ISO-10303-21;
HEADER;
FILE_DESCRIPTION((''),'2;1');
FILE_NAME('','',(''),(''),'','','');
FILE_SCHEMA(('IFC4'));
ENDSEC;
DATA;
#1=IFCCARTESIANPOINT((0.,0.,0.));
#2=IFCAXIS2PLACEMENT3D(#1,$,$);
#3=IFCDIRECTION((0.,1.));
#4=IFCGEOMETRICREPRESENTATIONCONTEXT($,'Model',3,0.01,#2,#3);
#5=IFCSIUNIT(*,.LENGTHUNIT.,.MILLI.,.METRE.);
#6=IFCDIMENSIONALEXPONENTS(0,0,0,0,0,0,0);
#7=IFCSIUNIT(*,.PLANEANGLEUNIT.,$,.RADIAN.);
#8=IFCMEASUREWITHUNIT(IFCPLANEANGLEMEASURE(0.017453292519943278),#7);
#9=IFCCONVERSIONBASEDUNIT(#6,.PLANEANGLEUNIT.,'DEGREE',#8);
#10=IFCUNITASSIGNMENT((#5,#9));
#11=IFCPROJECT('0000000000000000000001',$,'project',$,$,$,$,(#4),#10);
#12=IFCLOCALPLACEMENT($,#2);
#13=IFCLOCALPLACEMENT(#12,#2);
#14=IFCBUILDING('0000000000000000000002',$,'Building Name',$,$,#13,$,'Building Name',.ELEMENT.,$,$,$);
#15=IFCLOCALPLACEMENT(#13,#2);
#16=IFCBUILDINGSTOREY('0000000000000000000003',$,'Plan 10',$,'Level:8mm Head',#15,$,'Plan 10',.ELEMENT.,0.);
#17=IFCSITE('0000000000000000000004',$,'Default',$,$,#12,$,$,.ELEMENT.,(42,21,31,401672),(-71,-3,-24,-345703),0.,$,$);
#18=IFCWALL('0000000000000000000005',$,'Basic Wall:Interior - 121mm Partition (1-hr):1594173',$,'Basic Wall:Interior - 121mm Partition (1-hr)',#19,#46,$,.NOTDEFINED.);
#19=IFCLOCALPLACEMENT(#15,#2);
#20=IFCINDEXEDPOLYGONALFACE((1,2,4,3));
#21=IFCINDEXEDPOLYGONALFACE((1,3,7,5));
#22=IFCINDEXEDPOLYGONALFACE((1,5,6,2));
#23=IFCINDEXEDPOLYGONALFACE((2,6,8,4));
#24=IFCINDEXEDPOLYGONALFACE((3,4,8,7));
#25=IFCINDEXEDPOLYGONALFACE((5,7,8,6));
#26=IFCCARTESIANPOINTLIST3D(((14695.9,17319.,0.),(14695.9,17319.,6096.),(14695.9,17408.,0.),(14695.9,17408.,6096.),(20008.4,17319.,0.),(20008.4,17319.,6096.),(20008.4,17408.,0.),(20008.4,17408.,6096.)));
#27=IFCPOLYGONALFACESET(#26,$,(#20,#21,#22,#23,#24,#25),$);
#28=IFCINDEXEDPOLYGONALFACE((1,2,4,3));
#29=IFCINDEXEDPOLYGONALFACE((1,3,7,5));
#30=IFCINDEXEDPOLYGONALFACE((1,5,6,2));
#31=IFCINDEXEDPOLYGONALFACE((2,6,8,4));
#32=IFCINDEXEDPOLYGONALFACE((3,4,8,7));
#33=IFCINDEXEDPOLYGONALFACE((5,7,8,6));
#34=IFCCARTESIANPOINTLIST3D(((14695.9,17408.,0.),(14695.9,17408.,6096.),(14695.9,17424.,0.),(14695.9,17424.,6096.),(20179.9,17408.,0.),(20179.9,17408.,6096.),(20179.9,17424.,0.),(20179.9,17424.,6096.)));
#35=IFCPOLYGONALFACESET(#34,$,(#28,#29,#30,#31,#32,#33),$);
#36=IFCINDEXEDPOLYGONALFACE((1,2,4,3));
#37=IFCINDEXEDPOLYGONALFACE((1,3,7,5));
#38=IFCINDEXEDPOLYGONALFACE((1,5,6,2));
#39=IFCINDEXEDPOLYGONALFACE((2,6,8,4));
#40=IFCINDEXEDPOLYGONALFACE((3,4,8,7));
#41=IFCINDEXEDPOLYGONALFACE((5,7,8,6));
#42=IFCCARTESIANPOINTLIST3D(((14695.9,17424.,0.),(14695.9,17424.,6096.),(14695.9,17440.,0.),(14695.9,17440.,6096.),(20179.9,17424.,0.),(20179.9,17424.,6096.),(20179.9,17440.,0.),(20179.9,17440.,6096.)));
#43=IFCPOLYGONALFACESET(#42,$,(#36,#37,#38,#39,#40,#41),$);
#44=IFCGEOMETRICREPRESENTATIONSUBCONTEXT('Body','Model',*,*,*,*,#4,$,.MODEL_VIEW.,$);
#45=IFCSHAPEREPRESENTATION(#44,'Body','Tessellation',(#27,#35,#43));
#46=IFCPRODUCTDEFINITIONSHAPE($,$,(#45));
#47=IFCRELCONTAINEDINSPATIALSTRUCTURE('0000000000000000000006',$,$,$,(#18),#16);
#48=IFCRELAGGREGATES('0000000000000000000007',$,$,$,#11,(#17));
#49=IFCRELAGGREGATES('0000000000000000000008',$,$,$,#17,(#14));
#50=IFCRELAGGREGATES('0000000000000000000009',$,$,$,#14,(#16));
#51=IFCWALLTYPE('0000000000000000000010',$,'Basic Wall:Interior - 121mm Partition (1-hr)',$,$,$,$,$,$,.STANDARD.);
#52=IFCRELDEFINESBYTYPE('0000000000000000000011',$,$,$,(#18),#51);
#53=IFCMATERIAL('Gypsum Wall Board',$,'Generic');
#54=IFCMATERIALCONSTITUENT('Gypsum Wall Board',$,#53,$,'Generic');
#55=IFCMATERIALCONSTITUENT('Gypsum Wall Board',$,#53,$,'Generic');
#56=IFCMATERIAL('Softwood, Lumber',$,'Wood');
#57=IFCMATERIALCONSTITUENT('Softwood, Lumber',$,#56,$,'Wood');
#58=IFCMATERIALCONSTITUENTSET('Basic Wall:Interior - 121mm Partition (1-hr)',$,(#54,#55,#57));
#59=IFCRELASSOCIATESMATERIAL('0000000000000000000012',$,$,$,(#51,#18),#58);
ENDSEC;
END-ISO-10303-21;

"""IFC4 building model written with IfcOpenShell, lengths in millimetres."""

from ifc_helpers import new_model, entity, si_unit, converted_unit, direction, frame, origin, place, context, subcontext, project, spatial, indexed_curve, outline, extrude, material, constituent, constituent_set, type_object, element, save


model = new_model("IFC4")

# Units and contexts
model_context = context("Model", 3, precision=0.01, world=origin(), true_north=direction((0.0, 1.0)))
body_context = subcontext(model_context, "Body", "Model", "MODEL_VIEW")
ifc_project = project(units=[si_unit("LENGTHUNIT", "METRE", prefix="MILLI"), converted_unit("PLANEANGLEUNIT", "DEGREE", entity("IfcPlaneAngleMeasure", 0.017453292519943278), si_unit("PLANEANGLEUNIT", "RADIAN"), dimensions=[0, 0, 0, 0, 0, 0, 0])], contexts=[model_context])

# Site, building, storey
site_placement = place(None, origin())
site = spatial("IfcSite", under=ifc_project, at=site_placement, Name="Default", CompositionType="ELEMENT", RefLatitude=(42, 21, 31, 401672), RefLongitude=(-71, -3, -24, -345703), RefElevation=0.0)
building_placement = place(site_placement, origin())
building = spatial("IfcBuilding", under=site, at=building_placement, Name="Building Name", LongName="Building Name", CompositionType="ELEMENT")
storey_placement = place(building_placement, origin())
storey = spatial("IfcBuildingStorey", under=building, at=storey_placement, Name="Plan 10", ObjectType="Level:8mm Head", LongName="Plan 10", CompositionType="ELEMENT", Elevation=0.0)

# Wall
ifc_material_1 = material(Name="Gypsum Wall Board", Category="Generic")
ifc_material_2 = material(Name="Softwood, Lumber", Category="Wood")
ifc_constituent_1 = constituent(ifc_material_1, Name="Gypsum Wall Board", Category="Generic")
ifc_constituent_2 = constituent(ifc_material_1, Name="Gypsum Wall Board", Category="Generic")
ifc_constituent_3 = constituent(ifc_material_2, Name="Softwood, Lumber", Category="Wood")
ifc_constituent_set_1 = constituent_set(constituents=[ifc_constituent_1, ifc_constituent_2, ifc_constituent_3], Name="Basic Wall:Interior - 121mm Partition (1-hr)")
wall_type_1 = type_object("IfcWallType", Name="Basic Wall:Interior - 121mm Partition (1-hr)", PredefinedType="STANDARD", material=ifc_constituent_set_1)
wall_1_placement = place(storey_placement, frame((14695.9, 17379.5, 0.0)))
element("IfcWall", 1, at=wall_1_placement, inside=storey, type_object=wall_type_1, material=ifc_constituent_set_1, Name="Basic Wall:Interior - 121mm Partition (1-hr):1594173", ObjectType="Basic Wall:Interior - 121mm Partition (1-hr)", PredefinedType="NOTDEFINED", context=body_context, shape_type="SweptSolid", body=[
    extrude(outline(indexed_curve([(-44.5, -2656.3), (44.5, -2656.3), (44.5, 2656.3), (-44.5, 2656.3), (-44.5, -2656.3)], self_intersect=False)), frame((2656.3, -16.0, 0.0), z_axis=(0.0, 0.0, 1.0), x_axis=(0.0, 1.0, 0.0)), (0.0, 0.0, 1.0), 6096.0),
    extrude(outline(indexed_curve([(-2742.0, -8.0), (2742.0, -8.0), (2742.0, 8.0), (-2742.0, 8.0), (-2742.0, -8.0)], self_intersect=False)), frame((2742.0, 36.5, 0.0)), (0.0, 0.0, 1.0), 6096.0),
    extrude(outline(indexed_curve([(-8.0, -2742.0), (8.0, -2742.0), (8.0, 2742.0), (-8.0, 2742.0), (-8.0, -2742.0)], self_intersect=False)), frame((2742.0, 52.5, 0.0), z_axis=(0.0, 0.0, 1.0), x_axis=(0.0, -1.0, 0.0)), (0.0, 0.0, 1.0), 6096.0),
])

save(model, "model.ifc")
